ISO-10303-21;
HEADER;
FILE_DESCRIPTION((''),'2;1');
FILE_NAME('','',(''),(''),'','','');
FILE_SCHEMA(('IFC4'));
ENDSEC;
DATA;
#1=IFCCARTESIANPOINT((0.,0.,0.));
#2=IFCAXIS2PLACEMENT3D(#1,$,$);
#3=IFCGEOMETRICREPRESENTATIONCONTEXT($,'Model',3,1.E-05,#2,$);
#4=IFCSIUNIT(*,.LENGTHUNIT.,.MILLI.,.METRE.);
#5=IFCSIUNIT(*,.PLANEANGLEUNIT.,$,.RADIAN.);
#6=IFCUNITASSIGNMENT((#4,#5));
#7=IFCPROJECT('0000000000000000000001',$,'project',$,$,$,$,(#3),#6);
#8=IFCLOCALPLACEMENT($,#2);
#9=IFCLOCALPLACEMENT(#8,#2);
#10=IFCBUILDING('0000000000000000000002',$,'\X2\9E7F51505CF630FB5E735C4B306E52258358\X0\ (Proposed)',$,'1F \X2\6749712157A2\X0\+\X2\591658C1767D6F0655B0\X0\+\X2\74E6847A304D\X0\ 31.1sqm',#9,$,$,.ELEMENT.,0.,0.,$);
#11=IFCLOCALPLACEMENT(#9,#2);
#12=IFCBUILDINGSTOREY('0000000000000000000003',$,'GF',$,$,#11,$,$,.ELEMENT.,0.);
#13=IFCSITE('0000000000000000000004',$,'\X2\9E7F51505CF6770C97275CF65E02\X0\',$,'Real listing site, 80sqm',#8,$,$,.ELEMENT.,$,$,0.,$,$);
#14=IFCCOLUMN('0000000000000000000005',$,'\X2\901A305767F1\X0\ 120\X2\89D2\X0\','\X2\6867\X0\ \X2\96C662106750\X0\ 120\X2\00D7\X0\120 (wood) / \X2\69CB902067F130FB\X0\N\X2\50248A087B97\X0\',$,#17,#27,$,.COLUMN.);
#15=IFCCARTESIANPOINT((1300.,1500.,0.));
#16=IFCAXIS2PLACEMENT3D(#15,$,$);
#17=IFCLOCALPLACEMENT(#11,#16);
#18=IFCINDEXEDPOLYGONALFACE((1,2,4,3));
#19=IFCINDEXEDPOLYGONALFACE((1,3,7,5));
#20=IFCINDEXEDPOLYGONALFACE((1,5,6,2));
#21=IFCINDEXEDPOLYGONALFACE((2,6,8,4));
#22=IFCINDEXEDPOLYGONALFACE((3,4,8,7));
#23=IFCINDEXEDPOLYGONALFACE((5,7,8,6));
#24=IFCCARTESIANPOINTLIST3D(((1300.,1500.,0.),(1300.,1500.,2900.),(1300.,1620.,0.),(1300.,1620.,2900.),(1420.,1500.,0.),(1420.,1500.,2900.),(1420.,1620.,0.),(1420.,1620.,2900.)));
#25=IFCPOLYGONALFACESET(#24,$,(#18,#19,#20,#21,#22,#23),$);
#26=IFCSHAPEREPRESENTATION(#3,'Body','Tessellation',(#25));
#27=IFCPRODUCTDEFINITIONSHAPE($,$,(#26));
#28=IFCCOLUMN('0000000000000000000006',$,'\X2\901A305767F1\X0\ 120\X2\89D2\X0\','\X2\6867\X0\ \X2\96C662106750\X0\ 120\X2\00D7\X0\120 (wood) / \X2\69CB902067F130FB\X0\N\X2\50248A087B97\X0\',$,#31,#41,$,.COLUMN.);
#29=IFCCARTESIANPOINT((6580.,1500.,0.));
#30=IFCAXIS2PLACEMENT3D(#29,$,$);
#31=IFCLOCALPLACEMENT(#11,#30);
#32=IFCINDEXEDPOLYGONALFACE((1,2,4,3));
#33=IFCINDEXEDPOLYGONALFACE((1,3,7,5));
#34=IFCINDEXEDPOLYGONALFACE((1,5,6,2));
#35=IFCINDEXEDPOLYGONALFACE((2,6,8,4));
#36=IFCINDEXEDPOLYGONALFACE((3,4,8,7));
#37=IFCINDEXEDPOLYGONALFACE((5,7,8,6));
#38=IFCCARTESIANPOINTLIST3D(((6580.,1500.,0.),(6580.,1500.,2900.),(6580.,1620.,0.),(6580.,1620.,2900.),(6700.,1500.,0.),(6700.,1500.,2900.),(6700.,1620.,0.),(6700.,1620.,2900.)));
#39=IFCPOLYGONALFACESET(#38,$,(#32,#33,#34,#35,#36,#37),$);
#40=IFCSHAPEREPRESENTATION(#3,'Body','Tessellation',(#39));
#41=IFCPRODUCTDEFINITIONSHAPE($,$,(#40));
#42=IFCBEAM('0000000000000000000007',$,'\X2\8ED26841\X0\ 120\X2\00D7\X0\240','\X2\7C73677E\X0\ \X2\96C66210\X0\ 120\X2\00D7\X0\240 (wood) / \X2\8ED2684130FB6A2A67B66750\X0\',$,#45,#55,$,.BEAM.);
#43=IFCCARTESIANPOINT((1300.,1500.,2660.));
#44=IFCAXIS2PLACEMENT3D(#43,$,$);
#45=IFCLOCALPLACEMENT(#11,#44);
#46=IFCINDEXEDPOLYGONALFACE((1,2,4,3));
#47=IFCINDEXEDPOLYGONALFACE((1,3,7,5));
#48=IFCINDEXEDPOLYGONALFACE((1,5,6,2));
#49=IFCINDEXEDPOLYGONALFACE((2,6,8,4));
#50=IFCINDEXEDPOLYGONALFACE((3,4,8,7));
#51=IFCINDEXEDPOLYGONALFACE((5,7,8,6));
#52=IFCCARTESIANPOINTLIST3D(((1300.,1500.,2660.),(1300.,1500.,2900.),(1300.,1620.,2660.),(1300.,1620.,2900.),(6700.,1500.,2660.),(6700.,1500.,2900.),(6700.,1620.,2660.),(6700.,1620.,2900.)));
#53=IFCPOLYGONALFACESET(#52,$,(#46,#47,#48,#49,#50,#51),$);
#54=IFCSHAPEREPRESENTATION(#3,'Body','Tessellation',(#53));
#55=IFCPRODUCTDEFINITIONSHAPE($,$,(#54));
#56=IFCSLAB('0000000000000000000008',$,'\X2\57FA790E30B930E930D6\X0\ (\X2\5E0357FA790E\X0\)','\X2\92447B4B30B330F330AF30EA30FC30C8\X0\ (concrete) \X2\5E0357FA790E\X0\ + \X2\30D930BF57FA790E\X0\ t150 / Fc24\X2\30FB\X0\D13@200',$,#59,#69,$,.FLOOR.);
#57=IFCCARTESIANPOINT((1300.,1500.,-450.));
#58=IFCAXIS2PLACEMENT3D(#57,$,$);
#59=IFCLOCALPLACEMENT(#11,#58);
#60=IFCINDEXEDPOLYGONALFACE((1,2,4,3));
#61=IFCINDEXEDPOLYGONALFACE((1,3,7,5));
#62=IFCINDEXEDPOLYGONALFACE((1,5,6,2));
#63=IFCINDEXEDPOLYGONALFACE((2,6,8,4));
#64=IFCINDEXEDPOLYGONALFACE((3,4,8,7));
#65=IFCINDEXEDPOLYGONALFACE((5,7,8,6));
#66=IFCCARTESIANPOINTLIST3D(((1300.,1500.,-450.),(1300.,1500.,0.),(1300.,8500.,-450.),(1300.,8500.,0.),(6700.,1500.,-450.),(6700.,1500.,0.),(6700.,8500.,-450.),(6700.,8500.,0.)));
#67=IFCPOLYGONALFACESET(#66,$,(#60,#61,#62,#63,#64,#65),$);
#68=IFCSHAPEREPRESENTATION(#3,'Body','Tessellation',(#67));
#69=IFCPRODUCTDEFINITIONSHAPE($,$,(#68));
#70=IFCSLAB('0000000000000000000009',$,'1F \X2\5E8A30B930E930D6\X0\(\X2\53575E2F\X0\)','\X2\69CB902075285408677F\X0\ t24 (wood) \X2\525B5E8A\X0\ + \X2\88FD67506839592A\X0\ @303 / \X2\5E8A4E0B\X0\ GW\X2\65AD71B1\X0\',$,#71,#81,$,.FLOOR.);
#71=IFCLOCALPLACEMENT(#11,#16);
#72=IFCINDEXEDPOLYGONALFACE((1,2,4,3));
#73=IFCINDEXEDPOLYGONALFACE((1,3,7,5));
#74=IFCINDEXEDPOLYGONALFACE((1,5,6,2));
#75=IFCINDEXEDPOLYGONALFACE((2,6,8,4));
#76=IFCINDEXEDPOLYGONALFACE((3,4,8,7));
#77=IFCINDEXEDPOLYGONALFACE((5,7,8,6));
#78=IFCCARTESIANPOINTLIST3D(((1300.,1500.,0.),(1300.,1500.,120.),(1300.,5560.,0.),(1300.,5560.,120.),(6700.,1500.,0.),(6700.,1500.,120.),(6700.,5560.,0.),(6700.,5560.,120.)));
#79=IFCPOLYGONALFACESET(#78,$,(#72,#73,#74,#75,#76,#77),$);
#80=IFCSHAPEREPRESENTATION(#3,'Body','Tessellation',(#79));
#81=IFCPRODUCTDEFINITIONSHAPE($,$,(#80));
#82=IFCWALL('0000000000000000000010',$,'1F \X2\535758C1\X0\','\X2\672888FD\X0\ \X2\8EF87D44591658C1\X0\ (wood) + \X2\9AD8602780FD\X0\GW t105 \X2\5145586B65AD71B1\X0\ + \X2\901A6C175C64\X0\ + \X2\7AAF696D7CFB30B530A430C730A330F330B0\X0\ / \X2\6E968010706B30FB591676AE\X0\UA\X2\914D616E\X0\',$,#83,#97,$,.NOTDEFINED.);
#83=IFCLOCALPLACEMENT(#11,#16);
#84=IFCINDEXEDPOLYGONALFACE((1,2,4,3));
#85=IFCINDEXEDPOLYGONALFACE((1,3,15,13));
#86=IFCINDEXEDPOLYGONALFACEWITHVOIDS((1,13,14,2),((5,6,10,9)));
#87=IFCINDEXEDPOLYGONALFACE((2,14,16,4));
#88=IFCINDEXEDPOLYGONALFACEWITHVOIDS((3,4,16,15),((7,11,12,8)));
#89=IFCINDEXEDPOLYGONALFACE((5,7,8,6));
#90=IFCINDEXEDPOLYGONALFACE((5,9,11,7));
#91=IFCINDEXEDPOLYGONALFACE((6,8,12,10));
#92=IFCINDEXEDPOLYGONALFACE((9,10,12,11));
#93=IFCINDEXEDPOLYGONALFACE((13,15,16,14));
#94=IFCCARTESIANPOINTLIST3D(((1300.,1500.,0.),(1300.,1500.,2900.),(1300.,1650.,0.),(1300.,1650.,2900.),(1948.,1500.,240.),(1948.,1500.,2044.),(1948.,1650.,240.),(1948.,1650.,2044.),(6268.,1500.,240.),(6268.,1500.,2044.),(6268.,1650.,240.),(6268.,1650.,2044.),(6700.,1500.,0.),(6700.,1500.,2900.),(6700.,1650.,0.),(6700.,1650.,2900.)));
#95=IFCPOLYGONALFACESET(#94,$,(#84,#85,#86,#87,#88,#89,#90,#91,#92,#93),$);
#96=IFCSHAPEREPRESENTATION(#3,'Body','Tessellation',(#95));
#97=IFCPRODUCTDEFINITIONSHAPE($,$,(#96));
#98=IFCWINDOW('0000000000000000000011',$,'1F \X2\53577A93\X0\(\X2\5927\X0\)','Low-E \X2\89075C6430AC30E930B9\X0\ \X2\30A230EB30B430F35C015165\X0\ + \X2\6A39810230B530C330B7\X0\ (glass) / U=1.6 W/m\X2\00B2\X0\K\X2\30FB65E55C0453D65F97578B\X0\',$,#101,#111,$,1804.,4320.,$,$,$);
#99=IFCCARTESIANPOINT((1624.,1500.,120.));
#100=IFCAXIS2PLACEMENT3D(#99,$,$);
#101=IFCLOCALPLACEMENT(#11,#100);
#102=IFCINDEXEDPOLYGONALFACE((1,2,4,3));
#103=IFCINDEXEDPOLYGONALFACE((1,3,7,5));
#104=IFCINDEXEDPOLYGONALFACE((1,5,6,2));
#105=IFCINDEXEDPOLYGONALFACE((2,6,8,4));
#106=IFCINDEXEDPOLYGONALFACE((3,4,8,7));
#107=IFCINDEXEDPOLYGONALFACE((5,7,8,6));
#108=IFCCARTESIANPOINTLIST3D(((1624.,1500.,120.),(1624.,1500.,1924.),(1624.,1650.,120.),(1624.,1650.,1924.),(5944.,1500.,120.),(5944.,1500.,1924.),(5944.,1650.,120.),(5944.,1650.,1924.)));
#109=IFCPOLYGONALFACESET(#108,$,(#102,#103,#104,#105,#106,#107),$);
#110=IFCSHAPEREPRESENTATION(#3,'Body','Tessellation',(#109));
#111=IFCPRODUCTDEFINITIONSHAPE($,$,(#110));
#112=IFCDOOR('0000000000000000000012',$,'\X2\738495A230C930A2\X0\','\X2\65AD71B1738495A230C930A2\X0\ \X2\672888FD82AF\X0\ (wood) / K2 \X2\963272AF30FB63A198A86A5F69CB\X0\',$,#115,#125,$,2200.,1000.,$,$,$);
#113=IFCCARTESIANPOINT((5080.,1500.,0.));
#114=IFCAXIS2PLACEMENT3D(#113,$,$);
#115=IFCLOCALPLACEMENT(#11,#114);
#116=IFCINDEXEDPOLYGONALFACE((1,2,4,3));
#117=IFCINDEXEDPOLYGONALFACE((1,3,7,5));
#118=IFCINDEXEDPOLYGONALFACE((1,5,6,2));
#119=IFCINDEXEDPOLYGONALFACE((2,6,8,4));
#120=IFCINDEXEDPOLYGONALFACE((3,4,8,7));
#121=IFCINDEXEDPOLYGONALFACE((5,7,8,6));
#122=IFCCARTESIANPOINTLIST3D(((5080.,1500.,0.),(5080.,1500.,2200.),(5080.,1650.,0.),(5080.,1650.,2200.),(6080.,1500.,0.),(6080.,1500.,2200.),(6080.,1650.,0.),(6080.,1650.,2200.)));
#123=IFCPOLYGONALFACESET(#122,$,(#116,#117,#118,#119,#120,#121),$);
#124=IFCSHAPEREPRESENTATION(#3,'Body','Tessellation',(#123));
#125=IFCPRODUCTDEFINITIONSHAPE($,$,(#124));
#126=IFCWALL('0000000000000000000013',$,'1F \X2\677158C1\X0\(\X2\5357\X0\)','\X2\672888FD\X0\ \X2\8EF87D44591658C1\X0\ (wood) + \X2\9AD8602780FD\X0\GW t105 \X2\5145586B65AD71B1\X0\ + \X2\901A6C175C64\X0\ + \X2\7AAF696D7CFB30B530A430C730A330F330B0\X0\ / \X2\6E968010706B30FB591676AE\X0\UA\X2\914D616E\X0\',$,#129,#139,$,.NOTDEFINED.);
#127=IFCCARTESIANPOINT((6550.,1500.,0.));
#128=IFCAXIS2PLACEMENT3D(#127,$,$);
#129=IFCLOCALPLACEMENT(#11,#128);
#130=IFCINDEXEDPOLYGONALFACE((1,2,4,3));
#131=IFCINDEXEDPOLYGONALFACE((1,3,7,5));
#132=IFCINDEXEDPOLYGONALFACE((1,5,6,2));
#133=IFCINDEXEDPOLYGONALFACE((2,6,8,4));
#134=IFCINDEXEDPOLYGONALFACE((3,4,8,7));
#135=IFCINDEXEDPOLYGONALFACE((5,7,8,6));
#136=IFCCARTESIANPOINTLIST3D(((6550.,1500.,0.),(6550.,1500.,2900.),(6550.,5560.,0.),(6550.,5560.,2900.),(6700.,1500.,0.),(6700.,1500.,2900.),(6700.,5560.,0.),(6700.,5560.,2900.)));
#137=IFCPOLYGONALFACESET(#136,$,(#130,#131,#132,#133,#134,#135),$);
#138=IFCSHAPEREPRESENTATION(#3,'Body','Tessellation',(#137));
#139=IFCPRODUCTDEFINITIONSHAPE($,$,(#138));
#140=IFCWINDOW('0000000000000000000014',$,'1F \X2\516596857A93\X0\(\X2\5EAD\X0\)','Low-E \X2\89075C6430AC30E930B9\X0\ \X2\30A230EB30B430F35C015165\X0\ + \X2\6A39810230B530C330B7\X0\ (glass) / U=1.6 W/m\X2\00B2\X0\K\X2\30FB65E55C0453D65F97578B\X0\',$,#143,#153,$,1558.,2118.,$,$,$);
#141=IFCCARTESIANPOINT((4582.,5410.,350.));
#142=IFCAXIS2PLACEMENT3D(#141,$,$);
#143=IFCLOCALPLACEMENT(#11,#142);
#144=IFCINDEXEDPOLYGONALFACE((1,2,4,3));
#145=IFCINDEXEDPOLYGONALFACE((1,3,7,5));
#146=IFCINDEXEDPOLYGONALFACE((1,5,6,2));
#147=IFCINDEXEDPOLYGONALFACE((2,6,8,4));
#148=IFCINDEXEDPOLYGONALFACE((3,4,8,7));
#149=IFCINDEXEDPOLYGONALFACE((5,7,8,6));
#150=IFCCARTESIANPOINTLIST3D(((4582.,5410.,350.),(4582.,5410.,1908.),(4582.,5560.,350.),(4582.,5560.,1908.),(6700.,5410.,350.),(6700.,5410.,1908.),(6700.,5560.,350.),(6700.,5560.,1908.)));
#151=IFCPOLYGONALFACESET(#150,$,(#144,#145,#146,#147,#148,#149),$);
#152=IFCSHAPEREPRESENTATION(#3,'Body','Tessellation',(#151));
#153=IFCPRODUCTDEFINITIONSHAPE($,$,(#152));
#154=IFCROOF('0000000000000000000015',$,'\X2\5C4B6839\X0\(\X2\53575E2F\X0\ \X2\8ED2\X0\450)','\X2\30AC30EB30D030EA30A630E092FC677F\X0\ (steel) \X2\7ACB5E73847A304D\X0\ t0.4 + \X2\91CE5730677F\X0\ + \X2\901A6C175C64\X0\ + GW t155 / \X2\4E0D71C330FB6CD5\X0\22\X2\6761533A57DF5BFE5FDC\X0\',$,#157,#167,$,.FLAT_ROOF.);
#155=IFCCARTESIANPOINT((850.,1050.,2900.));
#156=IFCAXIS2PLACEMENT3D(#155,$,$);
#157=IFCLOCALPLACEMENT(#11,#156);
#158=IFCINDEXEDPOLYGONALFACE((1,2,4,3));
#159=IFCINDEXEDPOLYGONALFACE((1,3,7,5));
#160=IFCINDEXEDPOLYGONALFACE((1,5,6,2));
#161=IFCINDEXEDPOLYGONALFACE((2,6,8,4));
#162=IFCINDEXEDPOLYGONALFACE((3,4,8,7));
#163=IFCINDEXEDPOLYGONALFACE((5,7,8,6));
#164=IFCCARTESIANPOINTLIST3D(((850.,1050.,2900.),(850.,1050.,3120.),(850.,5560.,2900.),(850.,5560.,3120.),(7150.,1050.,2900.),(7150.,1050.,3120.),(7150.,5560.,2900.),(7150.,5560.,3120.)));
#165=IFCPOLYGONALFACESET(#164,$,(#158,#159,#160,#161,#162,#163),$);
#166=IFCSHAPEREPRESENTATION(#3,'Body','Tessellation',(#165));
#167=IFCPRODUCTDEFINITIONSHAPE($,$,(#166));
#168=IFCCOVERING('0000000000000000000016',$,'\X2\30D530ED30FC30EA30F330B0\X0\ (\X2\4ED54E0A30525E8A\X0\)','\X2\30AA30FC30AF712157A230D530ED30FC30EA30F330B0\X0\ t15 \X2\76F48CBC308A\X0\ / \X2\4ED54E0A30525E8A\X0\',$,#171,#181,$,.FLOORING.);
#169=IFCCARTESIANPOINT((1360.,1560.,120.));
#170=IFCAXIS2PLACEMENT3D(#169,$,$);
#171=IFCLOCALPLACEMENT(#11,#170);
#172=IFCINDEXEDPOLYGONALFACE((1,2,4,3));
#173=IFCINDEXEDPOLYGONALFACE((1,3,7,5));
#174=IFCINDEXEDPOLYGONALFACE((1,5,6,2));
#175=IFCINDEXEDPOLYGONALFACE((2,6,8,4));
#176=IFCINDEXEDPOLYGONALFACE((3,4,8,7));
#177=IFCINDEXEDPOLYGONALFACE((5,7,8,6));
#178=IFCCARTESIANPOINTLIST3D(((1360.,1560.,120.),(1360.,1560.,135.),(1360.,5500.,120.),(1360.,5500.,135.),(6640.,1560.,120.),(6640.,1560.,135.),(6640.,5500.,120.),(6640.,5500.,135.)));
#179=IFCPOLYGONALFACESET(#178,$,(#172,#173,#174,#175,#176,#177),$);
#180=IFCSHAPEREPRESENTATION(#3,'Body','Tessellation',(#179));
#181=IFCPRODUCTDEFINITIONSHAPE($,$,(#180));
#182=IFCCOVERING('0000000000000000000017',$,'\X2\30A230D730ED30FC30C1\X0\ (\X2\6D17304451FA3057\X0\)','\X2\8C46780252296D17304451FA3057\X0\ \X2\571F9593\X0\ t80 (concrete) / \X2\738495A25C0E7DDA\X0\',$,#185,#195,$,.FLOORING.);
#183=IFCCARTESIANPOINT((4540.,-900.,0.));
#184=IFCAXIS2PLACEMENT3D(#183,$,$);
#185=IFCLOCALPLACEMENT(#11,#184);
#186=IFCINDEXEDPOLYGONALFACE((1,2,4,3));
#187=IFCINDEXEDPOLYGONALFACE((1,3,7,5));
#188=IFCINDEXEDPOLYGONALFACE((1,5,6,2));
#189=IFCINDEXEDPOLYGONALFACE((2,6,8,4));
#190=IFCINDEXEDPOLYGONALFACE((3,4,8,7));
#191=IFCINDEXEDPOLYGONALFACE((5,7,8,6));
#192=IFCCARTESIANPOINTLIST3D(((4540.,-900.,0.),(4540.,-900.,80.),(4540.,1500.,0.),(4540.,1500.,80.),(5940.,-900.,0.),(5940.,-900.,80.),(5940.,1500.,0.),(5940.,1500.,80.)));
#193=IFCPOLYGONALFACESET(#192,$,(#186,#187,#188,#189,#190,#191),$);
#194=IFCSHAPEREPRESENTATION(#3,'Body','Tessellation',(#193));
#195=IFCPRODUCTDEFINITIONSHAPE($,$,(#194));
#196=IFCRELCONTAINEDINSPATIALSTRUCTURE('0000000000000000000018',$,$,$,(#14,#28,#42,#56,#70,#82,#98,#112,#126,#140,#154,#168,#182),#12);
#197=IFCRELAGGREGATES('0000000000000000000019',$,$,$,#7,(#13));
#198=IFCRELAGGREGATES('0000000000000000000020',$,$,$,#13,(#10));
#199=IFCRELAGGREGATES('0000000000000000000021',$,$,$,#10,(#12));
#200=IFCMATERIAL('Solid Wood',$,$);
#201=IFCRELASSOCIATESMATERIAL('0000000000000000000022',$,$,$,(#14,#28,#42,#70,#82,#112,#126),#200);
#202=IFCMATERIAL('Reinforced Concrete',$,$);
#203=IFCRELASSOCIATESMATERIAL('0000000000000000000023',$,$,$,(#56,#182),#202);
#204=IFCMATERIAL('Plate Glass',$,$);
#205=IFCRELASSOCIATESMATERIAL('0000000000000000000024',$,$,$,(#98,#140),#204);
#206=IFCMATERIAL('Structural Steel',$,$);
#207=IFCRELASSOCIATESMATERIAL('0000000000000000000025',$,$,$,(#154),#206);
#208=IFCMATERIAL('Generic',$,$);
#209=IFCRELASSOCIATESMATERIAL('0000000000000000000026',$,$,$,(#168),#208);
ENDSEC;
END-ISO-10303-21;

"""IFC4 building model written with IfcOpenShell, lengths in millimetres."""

from ifc_helpers import new_model, si_unit, frame, frame_2d, origin, place, context, project, spatial, rectangle, extrude, material, element, fill, save


model = new_model("IFC4")

# Units and contexts
model_context = context("Model", 3, precision=1e-05, world=origin())
ifc_project = project(units=[si_unit("LENGTHUNIT", "METRE", prefix="MILLI"), si_unit("PLANEANGLEUNIT", "RADIAN")], contexts=[model_context])

# Site, building, storey
site_placement = place(None, origin())
site = spatial("IfcSite", under=ifc_project, at=site_placement, Name="鹿児島県霧島市", ObjectType="Real listing site, 80sqm", CompositionType="ELEMENT", RefElevation=0.0)
building_placement = place(site_placement, origin())
building = spatial("IfcBuilding", under=site, at=building_placement, Name="鹿児島・平屋の別荘 (Proposed)", ObjectType="1F 杉無垢+外壁白漆喰+瓦葺き 31.1sqm", CompositionType="ELEMENT", ElevationOfRefHeight=0.0, ElevationOfTerrain=0.0)
storey_placement = place(building_placement, origin())
storey = spatial("IfcBuildingStorey", under=building, at=storey_placement, Name="GF", CompositionType="ELEMENT", Elevation=0.0)

# Columns
ifc_material_1 = material(Name="Solid Wood")
column_1_placement = place(storey_placement, frame((1300.0, 1500.0, 0.0)))
element("IfcColumn", 1, at=column_1_placement, inside=storey, material=ifc_material_1, Name="通し柱 120角", Description="桧 集成材 120×120 (wood) / 構造柱・N値計算", PredefinedType="COLUMN", context=model_context, shape_type="SweptSolid", body=[
    extrude(rectangle(XDim=120.0, YDim=120.0, at=frame_2d((60.0, 60.0))), frame((1300.0, 1500.0, 0.0)), (0.0, 0.0, 1.0), 2900.0),
])
column_2_placement = place(storey_placement, frame((6580.0, 1500.0, 0.0)))
element("IfcColumn", 2, at=column_2_placement, inside=storey, material=ifc_material_1, Name="通し柱 120角", Description="桧 集成材 120×120 (wood) / 構造柱・N値計算", PredefinedType="COLUMN", context=model_context, shape_type="SweptSolid", body=[
    extrude(rectangle(XDim=120.0, YDim=120.0, at=frame_2d((60.0, 60.0))), frame((6580.0, 1500.0, 0.0)), (0.0, 0.0, 1.0), 2900.0),
])

# Beam
beam_1_placement = place(storey_placement, frame((1300.0, 1500.0, 2660.0)))
element("IfcBeam", 3, at=beam_1_placement, inside=storey, material=ifc_material_1, Name="軒桁 120×240", Description="米松 集成 120×240 (wood) / 軒桁・横架材", PredefinedType="BEAM", context=model_context, shape_type="SweptSolid", body=[
    extrude(rectangle(XDim=5400.0, YDim=120.0, at=frame_2d((2700.0, 60.0))), frame((1300.0, 1500.0, 2660.0)), (0.0, 0.0, 1.0), 240.0),
])

# Slabs
ifc_material_2 = material(Name="Reinforced Concrete")
slab_1_placement = place(storey_placement, frame((1300.0, 1500.0, -450.0)))
element("IfcSlab", 4, at=slab_1_placement, inside=storey, material=ifc_material_2, Name="基礎スラブ (布基礎)", Description="鉄筋コンクリート (concrete) 布基礎 + ベタ基礎 t150 / Fc24・D13@200", PredefinedType="FLOOR", context=model_context, shape_type="SweptSolid", body=[
    extrude(rectangle(XDim=5400.0, YDim=7000.0, at=frame_2d((2700.0, 3500.0))), frame((1300.0, 1500.0, -450.0)), (0.0, 0.0, 1.0), 450.0),
])
slab_2_placement = place(storey_placement, frame((1300.0, 1500.0, 0.0)))
element("IfcSlab", 5, at=slab_2_placement, inside=storey, material=ifc_material_1, Name="1F 床スラブ(南帯)", Description="構造用合板 t24 (wood) 剛床 + 製材根太 @303 / 床下 GW断熱", PredefinedType="FLOOR", context=model_context, shape_type="SweptSolid", body=[
    extrude(rectangle(XDim=5400.0, YDim=4060.0, at=frame_2d((2700.0, 2030.0))), frame((1300.0, 1500.0, 0.0)), (0.0, 0.0, 1.0), 120.0),
])

# Wall, openings, window, door
wall_1_placement = place(storey_placement, frame((1300.0, 1500.0, 0.0)))
wall_1 = element("IfcWall", 6, at=wall_1_placement, inside=storey, material=ifc_material_1, Name="1F 南壁", Description="木製 軸組外壁 (wood) + 高性能GW t105 充填断熱 + 通気層 + 窯業系サイディング / 準耐火・外皮UA配慮", PredefinedType="NOTDEFINED", context=model_context, shape_type="SweptSolid", body=[
    extrude(rectangle(XDim=5400.0, YDim=150.0, at=frame_2d((2700.0, 75.0))), frame((1300.0, 1500.0, 0.0)), (0.0, 0.0, 1.0), 2900.0),
])
opening_1_placement = place(storey_placement, frame((1624.0, 1500.0, 120.0)))
opening_1 = element("IfcOpeningElement", 7, at=opening_1_placement, cuts=wall_1, PredefinedType="NOTDEFINED", context=model_context, shape_type="SweptSolid", body=[
    extrude(rectangle(XDim=4320.0, YDim=150.0, at=frame_2d((2160.0, 75.0))), frame((1624.0, 1500.0, 120.0)), (0.0, 0.0, 1.0), 1804.0),
])
opening_2_placement = place(storey_placement, frame((5080.0, 1500.0, 0.0)))
opening_2 = element("IfcOpeningElement", 8, at=opening_2_placement, cuts=wall_1, PredefinedType="NOTDEFINED", context=model_context, shape_type="SweptSolid", body=[
    extrude(rectangle(XDim=1000.0, YDim=150.0, at=frame_2d((500.0, 75.0))), frame((5080.0, 1500.0, 0.0)), (0.0, 0.0, 1.0), 2200.0),
])
ifc_material_3 = material(Name="Plate Glass")
window_1_placement = place(storey_placement, frame((1624.0, 1500.0, 120.0)))
window_1 = element("IfcWindow", 9, at=window_1_placement, inside=storey, material=ifc_material_3, Name="1F 南窓(大)", Description="Low-E 複層ガラス アルゴン封入 + 樹脂サッシ (glass) / U=1.6 W/m²K・日射取得型", OverallHeight=1804.0, OverallWidth=4320.0, context=model_context, shape_type="SweptSolid", body=[
    extrude(rectangle(XDim=4320.0, YDim=150.0, at=frame_2d((2160.0, 75.0))), frame((1624.0, 1500.0, 120.0)), (0.0, 0.0, 1.0), 1804.0),
])
fill(opening_1, window_1)
door_1_placement = place(storey_placement, frame((5080.0, 1500.0, 0.0)))
door_1 = element("IfcDoor", 10, at=door_1_placement, inside=storey, material=ifc_material_1, Name="玄関ドア", Description="断熱玄関ドア 木製芯 (wood) / K2 防犯・採風機構", OverallHeight=2200.0, OverallWidth=1000.0, context=model_context, shape_type="SweptSolid", body=[
    extrude(rectangle(XDim=1000.0, YDim=150.0, at=frame_2d((500.0, 75.0))), frame((5080.0, 1500.0, 0.0)), (0.0, 0.0, 1.0), 2200.0),
])
fill(opening_2, door_1)

# Wall, opening, window
wall_2_placement = place(storey_placement, frame((6550.0, 1500.0, 0.0)))
wall_2 = element("IfcWall", 11, at=wall_2_placement, inside=storey, material=ifc_material_1, Name="1F 東壁(南)", Description="木製 軸組外壁 (wood) + 高性能GW t105 充填断熱 + 通気層 + 窯業系サイディング / 準耐火・外皮UA配慮", PredefinedType="NOTDEFINED", context=model_context, shape_type="SweptSolid", body=[
    extrude(rectangle(XDim=150.0, YDim=4060.0, at=frame_2d((75.0, 2030.0))), frame((6550.0, 1500.0, 0.0)), (0.0, 0.0, 1.0), 2900.0),
])
opening_3_placement = place(storey_placement, frame((4582.0, 5410.0, 350.0)))
opening_3 = element("IfcOpeningElement", 12, at=opening_3_placement, cuts=wall_2, PredefinedType="NOTDEFINED", context=model_context, shape_type="SweptSolid", body=[
    extrude(rectangle(XDim=2118.0, YDim=150.0, at=frame_2d((1059.0, 75.0))), frame((4582.0, 5410.0, 350.0)), (0.0, 0.0, 1.0), 1558.0),
])
window_2_placement = place(storey_placement, frame((4582.0, 5410.0, 350.0)))
window_2 = element("IfcWindow", 13, at=window_2_placement, inside=storey, material=ifc_material_3, Name="1F 入隅窓(庭)", Description="Low-E 複層ガラス アルゴン封入 + 樹脂サッシ (glass) / U=1.6 W/m²K・日射取得型", OverallHeight=1558.0, OverallWidth=2118.0, context=model_context, shape_type="SweptSolid", body=[
    extrude(rectangle(XDim=2118.0, YDim=150.0, at=frame_2d((1059.0, 75.0))), frame((4582.0, 5410.0, 350.0)), (0.0, 0.0, 1.0), 1558.0),
])
fill(opening_3, window_2)

# Roof
ifc_material_4 = material(Name="Structural Steel")
roof_placement = place(storey_placement, frame((850.0, 1050.0, 2900.0)))
element("IfcRoof", 14, at=roof_placement, inside=storey, material=ifc_material_4, Name="屋根(南帯 軒450)", Description="ガルバリウム鋼板 (steel) 立平葺き t0.4 + 野地板 + 通気層 + GW t155 / 不燃・法22条区域対応", PredefinedType="FLAT_ROOF", context=model_context, shape_type="SweptSolid", body=[
    extrude(rectangle(XDim=6300.0, YDim=4510.0, at=frame_2d((3150.0, 2255.0))), frame((850.0, 1050.0, 2900.0)), (0.0, 0.0, 1.0), 220.0),
])

# Coverings
ifc_material_5 = material(Name="Generic")
covering_1_placement = place(storey_placement, frame((1360.0, 1560.0, 120.0)))
element("IfcCovering", 15, at=covering_1_placement, inside=storey, material=ifc_material_5, Name="フローリング (仕上げ床)", Description="オーク無垢フローリング t15 直貼り / 仕上げ床", PredefinedType="FLOORING", context=model_context, shape_type="SweptSolid", body=[
    extrude(rectangle(XDim=5280.0, YDim=3940.0, at=frame_2d((2640.0, 1970.0))), frame((1360.0, 1560.0, 120.0)), (0.0, 0.0, 1.0), 15.0),
])
covering_2_placement = place(storey_placement, frame((4540.0, -900.0, 0.0)))
element("IfcCovering", 16, at=covering_2_placement, inside=storey, material=ifc_material_2, Name="アプローチ (洗い出し)", Description="豆砂利洗い出し 土間 t80 (concrete) / 玄関導線", PredefinedType="FLOORING", context=model_context, shape_type="SweptSolid", body=[
    extrude(rectangle(XDim=1400.0, YDim=2400.0, at=frame_2d((700.0, 1200.0))), frame((4540.0, -900.0, 0.0)), (0.0, 0.0, 1.0), 80.0),
])

save(model, "model.ifc")
